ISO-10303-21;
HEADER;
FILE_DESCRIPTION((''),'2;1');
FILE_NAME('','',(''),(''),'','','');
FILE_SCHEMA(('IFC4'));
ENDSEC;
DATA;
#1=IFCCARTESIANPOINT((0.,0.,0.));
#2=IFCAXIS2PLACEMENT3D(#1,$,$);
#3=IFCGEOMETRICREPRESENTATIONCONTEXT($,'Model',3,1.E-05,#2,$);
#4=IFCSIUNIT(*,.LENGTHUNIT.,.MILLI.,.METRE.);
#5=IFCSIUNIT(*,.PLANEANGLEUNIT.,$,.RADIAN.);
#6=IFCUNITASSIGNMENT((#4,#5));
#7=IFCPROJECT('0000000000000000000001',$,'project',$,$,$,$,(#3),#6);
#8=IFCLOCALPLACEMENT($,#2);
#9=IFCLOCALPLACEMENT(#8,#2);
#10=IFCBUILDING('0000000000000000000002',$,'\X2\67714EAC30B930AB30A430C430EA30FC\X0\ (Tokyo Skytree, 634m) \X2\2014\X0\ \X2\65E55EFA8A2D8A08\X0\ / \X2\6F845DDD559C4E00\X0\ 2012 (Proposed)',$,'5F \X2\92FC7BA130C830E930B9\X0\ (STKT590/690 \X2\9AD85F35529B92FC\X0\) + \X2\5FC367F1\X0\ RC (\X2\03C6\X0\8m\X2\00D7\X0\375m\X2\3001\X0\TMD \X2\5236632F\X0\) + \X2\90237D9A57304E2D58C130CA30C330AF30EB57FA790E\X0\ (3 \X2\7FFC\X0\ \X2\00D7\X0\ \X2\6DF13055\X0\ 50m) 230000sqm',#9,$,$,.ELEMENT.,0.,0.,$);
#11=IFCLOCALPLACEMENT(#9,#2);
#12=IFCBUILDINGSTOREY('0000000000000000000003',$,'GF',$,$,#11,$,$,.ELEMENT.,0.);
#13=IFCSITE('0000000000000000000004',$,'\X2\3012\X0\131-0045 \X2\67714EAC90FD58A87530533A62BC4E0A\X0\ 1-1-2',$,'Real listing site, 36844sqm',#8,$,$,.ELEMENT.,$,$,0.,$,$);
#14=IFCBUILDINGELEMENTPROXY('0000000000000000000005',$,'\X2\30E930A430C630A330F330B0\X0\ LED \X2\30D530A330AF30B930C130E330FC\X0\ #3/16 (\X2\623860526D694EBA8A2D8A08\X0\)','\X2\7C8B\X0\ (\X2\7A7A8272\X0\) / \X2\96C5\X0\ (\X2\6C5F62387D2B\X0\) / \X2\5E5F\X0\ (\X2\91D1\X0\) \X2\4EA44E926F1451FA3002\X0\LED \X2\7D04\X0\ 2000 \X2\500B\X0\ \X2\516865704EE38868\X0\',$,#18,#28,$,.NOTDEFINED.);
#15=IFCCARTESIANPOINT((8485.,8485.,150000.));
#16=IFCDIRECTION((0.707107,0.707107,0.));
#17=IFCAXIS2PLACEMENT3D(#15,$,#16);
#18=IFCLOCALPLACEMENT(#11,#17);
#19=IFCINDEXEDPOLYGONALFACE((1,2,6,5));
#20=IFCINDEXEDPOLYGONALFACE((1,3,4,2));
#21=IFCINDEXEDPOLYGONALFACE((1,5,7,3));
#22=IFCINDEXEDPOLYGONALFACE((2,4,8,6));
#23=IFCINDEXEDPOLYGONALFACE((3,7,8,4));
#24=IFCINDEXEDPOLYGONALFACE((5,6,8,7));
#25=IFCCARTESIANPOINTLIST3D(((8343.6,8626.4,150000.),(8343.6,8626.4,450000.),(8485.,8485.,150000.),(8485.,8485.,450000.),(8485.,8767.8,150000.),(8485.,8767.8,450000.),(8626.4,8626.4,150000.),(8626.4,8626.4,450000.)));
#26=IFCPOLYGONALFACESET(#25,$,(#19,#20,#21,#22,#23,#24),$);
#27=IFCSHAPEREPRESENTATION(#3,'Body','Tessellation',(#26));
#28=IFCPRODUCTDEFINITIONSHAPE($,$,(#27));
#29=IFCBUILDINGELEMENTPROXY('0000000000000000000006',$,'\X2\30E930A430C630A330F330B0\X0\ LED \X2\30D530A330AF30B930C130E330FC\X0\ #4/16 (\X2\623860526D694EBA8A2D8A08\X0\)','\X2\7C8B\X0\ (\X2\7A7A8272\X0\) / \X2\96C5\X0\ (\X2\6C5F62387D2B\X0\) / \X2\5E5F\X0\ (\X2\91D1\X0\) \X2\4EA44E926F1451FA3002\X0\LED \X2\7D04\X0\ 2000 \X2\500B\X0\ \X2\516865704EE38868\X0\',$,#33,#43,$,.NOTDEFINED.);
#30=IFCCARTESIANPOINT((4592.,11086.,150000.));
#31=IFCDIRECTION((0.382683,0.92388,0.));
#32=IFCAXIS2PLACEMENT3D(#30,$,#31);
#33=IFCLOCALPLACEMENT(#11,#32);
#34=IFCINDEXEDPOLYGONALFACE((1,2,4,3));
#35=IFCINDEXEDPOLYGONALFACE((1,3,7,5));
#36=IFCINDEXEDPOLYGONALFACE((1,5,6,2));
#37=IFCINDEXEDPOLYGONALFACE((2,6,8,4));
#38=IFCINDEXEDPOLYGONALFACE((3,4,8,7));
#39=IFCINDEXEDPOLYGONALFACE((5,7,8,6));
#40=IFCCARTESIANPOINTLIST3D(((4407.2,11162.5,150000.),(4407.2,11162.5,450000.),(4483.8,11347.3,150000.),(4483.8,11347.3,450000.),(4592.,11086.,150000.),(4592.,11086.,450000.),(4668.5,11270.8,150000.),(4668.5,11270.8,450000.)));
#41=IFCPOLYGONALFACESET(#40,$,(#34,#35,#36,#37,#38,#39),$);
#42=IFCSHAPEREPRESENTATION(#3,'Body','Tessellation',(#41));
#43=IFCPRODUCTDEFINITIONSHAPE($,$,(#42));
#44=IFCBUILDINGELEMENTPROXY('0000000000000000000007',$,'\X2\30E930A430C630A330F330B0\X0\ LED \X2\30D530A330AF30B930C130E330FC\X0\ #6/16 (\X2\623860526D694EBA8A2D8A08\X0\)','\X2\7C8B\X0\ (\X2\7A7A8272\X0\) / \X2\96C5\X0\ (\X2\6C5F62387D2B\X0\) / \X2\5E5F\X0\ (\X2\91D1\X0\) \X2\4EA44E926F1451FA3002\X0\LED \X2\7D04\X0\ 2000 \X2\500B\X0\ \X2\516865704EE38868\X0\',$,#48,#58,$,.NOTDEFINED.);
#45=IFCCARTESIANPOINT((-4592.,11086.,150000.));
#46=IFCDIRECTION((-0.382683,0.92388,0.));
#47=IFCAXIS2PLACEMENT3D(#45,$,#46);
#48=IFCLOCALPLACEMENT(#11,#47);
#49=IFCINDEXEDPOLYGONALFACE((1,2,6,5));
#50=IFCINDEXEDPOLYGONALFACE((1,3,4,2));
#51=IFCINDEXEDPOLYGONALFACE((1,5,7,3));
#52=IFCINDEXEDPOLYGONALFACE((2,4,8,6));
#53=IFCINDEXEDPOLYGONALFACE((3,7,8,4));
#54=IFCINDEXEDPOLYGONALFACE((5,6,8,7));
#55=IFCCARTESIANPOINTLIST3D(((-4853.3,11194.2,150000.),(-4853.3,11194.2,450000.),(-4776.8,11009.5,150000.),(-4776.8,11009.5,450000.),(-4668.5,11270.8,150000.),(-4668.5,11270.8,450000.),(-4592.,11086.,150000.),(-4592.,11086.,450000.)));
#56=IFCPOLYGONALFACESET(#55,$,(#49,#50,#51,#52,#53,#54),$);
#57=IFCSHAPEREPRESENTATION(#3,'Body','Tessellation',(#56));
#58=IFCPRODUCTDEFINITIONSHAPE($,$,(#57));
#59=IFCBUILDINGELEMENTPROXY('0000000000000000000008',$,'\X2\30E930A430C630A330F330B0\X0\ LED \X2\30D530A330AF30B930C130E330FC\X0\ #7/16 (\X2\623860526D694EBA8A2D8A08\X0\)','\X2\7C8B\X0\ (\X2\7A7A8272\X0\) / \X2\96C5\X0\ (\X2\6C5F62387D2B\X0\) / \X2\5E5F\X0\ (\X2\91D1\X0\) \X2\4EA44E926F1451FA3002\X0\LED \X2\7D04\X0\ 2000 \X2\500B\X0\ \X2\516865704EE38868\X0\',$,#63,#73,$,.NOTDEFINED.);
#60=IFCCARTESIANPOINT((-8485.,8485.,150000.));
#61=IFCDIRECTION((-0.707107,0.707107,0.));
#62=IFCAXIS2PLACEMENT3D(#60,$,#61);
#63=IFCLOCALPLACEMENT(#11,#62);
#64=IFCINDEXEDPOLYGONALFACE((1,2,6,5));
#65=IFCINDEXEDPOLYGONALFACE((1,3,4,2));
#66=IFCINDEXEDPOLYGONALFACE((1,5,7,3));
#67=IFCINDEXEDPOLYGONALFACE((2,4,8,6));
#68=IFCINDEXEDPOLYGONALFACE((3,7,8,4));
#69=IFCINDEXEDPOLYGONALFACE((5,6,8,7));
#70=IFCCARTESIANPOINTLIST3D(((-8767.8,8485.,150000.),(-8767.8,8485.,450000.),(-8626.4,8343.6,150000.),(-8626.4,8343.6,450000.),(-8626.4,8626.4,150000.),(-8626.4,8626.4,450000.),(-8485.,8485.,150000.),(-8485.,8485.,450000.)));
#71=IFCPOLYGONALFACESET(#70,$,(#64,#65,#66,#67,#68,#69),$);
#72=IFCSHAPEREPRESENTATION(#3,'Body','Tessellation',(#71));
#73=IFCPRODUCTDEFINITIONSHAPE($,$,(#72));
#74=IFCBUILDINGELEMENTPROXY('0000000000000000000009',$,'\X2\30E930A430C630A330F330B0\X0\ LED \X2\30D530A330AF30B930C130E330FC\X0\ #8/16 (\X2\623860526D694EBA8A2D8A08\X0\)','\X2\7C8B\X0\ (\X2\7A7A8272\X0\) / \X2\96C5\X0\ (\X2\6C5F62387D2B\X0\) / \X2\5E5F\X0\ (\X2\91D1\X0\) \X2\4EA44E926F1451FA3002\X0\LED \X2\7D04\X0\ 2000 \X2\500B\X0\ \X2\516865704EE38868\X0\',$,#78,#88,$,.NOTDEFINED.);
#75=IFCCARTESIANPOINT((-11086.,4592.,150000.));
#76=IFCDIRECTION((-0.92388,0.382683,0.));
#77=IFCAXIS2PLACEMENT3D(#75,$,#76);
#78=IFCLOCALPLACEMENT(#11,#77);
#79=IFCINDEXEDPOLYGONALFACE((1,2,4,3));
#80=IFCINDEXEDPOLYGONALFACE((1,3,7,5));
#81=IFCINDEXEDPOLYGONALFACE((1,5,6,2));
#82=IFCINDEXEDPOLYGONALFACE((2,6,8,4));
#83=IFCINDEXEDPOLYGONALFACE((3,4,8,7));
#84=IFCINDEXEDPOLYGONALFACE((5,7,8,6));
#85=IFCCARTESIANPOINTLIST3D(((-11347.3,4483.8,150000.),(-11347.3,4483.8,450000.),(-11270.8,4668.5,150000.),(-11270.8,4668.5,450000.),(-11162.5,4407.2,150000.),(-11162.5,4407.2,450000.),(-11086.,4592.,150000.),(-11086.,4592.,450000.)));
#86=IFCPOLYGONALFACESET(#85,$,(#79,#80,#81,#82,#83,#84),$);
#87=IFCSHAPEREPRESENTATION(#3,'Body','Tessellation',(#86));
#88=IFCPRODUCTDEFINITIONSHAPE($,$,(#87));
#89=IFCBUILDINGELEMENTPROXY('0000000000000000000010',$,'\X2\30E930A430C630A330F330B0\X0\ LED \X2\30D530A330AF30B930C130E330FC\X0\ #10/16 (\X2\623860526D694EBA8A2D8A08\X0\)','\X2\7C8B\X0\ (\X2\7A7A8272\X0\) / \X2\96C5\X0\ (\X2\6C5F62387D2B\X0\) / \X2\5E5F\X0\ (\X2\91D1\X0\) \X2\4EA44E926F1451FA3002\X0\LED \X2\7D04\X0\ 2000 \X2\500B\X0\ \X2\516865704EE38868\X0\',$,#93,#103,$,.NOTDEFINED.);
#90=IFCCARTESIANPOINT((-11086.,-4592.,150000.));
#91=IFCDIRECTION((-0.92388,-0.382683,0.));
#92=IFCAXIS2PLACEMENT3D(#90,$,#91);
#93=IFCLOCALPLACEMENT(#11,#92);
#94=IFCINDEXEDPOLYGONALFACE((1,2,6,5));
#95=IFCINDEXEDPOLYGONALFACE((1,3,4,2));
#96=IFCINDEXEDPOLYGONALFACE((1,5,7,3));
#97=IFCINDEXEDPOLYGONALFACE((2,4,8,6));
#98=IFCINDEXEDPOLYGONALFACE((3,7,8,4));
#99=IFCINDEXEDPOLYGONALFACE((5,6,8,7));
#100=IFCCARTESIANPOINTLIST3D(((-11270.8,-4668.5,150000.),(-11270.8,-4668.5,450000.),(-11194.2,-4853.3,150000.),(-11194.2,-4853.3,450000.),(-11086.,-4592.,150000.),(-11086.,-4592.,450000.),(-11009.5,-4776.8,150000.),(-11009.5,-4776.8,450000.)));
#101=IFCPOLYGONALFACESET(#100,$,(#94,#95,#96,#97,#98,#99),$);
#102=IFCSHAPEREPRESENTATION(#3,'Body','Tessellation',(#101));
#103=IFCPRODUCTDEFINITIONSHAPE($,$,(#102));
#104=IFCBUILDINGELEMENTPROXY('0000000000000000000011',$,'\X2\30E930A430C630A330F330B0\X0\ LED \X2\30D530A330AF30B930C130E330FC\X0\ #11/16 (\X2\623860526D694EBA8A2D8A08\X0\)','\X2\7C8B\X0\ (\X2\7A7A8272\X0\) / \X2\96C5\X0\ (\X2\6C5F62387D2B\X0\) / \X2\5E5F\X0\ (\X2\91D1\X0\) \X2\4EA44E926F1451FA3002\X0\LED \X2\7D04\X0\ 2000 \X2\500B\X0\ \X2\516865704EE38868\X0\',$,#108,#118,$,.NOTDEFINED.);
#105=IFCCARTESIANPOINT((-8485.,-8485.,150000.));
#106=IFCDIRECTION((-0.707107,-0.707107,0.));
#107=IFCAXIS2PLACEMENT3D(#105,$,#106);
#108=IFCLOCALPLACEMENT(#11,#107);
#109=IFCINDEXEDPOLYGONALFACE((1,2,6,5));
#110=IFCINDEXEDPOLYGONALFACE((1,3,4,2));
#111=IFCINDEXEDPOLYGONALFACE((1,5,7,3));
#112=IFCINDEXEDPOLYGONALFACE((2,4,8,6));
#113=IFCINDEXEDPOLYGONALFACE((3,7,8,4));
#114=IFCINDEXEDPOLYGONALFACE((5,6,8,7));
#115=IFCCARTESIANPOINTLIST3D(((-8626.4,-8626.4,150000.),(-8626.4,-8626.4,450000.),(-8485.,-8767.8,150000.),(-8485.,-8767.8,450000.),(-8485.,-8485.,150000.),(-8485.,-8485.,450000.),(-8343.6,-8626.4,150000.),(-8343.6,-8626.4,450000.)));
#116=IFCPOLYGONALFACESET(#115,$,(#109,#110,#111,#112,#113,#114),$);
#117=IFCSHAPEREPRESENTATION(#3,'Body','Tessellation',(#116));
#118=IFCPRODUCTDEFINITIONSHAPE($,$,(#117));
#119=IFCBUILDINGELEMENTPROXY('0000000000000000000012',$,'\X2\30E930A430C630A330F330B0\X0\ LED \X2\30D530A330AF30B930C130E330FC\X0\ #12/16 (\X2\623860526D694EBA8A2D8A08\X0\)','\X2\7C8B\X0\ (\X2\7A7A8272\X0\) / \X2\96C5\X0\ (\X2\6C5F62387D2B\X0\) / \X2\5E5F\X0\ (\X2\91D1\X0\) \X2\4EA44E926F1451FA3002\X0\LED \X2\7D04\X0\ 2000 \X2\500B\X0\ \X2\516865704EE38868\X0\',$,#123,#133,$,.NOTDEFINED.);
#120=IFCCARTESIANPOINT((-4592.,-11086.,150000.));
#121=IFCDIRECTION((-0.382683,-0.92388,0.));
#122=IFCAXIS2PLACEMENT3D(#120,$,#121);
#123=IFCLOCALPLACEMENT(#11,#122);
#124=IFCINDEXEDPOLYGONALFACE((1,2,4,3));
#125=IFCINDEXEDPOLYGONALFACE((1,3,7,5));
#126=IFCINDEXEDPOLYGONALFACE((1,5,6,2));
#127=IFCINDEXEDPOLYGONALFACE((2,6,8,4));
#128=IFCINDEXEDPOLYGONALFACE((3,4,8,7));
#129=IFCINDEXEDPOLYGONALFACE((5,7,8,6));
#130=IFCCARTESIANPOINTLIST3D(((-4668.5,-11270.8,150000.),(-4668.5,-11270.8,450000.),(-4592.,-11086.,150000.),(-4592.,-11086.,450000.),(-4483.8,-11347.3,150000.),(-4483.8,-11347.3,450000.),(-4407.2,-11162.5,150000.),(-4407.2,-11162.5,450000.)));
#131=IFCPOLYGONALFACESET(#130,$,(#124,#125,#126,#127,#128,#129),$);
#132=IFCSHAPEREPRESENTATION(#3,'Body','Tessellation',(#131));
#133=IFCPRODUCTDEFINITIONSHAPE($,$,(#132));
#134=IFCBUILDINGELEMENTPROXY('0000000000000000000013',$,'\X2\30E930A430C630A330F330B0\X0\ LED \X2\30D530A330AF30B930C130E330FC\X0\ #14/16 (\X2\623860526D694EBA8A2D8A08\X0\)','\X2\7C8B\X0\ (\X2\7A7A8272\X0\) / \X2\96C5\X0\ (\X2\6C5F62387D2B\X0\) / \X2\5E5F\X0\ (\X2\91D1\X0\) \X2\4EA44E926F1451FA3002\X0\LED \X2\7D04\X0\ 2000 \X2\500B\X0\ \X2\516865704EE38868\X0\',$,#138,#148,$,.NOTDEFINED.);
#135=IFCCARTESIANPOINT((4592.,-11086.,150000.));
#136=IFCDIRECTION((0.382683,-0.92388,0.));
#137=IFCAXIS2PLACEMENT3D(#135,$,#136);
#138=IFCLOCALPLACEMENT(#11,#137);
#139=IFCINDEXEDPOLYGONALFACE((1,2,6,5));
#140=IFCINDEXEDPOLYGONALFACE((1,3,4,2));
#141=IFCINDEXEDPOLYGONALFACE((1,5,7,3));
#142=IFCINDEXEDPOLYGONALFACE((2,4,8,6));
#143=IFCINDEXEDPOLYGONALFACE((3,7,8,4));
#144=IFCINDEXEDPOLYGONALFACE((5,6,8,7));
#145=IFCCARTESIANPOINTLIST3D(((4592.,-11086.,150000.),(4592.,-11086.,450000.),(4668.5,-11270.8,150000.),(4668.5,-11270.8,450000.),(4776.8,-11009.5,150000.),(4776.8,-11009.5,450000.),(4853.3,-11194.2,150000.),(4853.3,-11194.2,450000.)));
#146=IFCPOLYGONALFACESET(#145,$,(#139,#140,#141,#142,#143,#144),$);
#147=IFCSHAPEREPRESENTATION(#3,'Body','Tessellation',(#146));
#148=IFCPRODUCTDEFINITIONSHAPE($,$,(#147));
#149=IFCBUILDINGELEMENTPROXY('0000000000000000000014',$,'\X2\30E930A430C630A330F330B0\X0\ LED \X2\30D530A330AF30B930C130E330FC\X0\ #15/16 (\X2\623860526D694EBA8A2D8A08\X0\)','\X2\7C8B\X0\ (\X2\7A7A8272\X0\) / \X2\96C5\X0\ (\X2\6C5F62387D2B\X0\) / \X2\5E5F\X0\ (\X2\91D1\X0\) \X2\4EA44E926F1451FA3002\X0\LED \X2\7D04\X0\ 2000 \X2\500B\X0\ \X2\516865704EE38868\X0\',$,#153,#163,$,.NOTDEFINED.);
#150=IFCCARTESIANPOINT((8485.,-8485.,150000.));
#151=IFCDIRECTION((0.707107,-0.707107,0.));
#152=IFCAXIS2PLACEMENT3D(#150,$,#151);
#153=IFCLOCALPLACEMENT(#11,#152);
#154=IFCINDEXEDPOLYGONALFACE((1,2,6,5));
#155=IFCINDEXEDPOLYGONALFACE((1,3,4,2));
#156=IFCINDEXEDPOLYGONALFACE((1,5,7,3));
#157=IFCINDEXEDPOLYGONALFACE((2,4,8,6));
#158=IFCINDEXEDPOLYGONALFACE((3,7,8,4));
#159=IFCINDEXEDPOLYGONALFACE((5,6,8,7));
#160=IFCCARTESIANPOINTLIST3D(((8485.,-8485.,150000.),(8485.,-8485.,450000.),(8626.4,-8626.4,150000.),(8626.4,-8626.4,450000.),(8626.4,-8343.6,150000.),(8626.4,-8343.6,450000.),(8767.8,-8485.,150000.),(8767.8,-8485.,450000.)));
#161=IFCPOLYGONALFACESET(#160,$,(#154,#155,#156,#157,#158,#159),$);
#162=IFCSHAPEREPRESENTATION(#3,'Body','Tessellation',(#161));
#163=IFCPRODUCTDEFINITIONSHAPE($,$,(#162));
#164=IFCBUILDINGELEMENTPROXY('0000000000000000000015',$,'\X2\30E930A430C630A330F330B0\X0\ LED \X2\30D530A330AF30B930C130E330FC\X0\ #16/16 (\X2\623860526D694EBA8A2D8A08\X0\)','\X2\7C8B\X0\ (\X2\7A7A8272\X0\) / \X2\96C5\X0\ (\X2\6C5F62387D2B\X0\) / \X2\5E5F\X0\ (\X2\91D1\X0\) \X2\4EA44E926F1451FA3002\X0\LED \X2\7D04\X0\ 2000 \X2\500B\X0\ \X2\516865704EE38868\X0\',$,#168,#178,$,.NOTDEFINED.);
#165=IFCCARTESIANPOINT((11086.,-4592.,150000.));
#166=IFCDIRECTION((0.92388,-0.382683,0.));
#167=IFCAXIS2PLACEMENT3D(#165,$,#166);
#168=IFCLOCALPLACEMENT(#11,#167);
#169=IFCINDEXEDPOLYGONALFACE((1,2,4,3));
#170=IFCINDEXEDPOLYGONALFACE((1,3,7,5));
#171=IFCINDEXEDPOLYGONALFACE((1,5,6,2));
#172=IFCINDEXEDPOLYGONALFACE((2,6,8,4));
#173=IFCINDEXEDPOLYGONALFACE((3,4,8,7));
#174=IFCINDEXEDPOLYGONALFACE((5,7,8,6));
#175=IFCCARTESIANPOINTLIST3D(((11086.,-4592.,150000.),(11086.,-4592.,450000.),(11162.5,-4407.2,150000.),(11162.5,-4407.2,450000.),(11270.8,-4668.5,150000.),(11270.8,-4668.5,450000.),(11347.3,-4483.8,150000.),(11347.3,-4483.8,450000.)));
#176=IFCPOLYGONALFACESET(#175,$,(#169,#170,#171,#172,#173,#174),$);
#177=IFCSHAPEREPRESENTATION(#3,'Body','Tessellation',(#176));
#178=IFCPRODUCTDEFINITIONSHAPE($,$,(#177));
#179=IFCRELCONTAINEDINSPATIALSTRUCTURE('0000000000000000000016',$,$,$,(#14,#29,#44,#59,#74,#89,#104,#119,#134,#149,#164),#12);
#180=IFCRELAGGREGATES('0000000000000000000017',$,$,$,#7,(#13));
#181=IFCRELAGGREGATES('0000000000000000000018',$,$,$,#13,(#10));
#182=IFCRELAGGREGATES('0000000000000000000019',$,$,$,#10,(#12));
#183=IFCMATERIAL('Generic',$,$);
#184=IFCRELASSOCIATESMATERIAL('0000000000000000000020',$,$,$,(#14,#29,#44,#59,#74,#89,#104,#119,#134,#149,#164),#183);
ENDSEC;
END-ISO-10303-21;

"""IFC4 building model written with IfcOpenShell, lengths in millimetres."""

from ifc_helpers import new_model, si_unit, frame, frame_2d, origin, place, context, project, spatial, rectangle, extrude, material, element, save


model = new_model("IFC4")

# Units and contexts
model_context = context("Model", 3, precision=1e-05, world=origin())
ifc_project = project(units=[si_unit("LENGTHUNIT", "METRE", prefix="MILLI"), si_unit("PLANEANGLEUNIT", "RADIAN")], contexts=[model_context])

# Site, building, storey
site_placement = place(None, origin())
site = spatial("IfcSite", under=ifc_project, at=site_placement, Name="〒131-0045 東京都墨田区押上 1-1-2", ObjectType="Real listing site, 36844sqm", CompositionType="ELEMENT", RefElevation=0.0)
building_placement = place(site_placement, origin())
building = spatial("IfcBuilding", under=site, at=building_placement, Name="東京スカイツリー (Tokyo Skytree, 634m) — 日建設計 / 澄川喜一 2012 (Proposed)", ObjectType="5F 鋼管トラス (STKT590/690 高張力鋼) + 心柱 RC (φ8m×375m、TMD 制振) + 連続地中壁ナックル基礎 (3 翼 × 深さ 50m) 230000sqm", CompositionType="ELEMENT", ElevationOfRefHeight=0.0, ElevationOfTerrain=0.0)
storey_placement = place(building_placement, origin())
storey = spatial("IfcBuildingStorey", under=building, at=storey_placement, Name="GF", CompositionType="ELEMENT", Elevation=0.0)

# Shared definitions
ifc_material = material(Name="Generic")

# Building element proxies
proxy_1_placement = place(storey_placement, frame((8485.0, 8485.0, 150000.0), x_axis=(0.707107, 0.707107, 0.0)))
element("IfcBuildingElementProxy", 1, at=proxy_1_placement, inside=storey, material=ifc_material, Name="ライティング LED フィクスチャー #3/16 (戸恒浩人設計)", Description="粋 (空色) / 雅 (江戸紫) / 幟 (金) 交互演出。LED 約 2000 個 全数代表", PredefinedType="NOTDEFINED", context=model_context, shape_type="SweptSolid", body=[
    extrude(rectangle(XDim=200.0, YDim=200.0, at=frame_2d((100.0, 100.0))), frame((8485.0, 8485.0, 150000.0), x_axis=(0.707107, 0.707107, 0.0)), (0.0, 0.0, 1.0), 300000.0),
])
proxy_2_placement = place(storey_placement, frame((4592.0, 11086.0, 150000.0), x_axis=(0.382683, 0.92388, 0.0)))
element("IfcBuildingElementProxy", 2, at=proxy_2_placement, inside=storey, material=ifc_material, Name="ライティング LED フィクスチャー #4/16 (戸恒浩人設計)", Description="粋 (空色) / 雅 (江戸紫) / 幟 (金) 交互演出。LED 約 2000 個 全数代表", PredefinedType="NOTDEFINED", context=model_context, shape_type="SweptSolid", body=[
    extrude(rectangle(XDim=200.0, YDim=200.0, at=frame_2d((100.0, 100.0))), frame((4592.0, 11086.0, 150000.0), x_axis=(0.382683, 0.92388, 0.0)), (0.0, 0.0, 1.0), 300000.0),
])
proxy_3_placement = place(storey_placement, frame((-4592.0, 11086.0, 150000.0), x_axis=(-0.382683, 0.92388, 0.0)))
element("IfcBuildingElementProxy", 3, at=proxy_3_placement, inside=storey, material=ifc_material, Name="ライティング LED フィクスチャー #6/16 (戸恒浩人設計)", Description="粋 (空色) / 雅 (江戸紫) / 幟 (金) 交互演出。LED 約 2000 個 全数代表", PredefinedType="NOTDEFINED", context=model_context, shape_type="SweptSolid", body=[
    extrude(rectangle(XDim=200.0, YDim=200.0, at=frame_2d((100.0, 100.0))), frame((-4592.0, 11086.0, 150000.0), x_axis=(-0.382683, 0.92388, 0.0)), (0.0, 0.0, 1.0), 300000.0),
])
proxy_4_placement = place(storey_placement, frame((-8485.0, 8485.0, 150000.0), x_axis=(-0.707107, 0.707107, 0.0)))
element("IfcBuildingElementProxy", 4, at=proxy_4_placement, inside=storey, material=ifc_material, Name="ライティング LED フィクスチャー #7/16 (戸恒浩人設計)", Description="粋 (空色) / 雅 (江戸紫) / 幟 (金) 交互演出。LED 約 2000 個 全数代表", PredefinedType="NOTDEFINED", context=model_context, shape_type="SweptSolid", body=[
    extrude(rectangle(XDim=200.0, YDim=200.0, at=frame_2d((100.0, 100.0))), frame((-8485.0, 8485.0, 150000.0), x_axis=(-0.707107, 0.707107, 0.0)), (0.0, 0.0, 1.0), 300000.0),
])
proxy_5_placement = place(storey_placement, frame((-11086.0, 4592.0, 150000.0), x_axis=(-0.92388, 0.382683, 0.0)))
element("IfcBuildingElementProxy", 5, at=proxy_5_placement, inside=storey, material=ifc_material, Name="ライティング LED フィクスチャー #8/16 (戸恒浩人設計)", Description="粋 (空色) / 雅 (江戸紫) / 幟 (金) 交互演出。LED 約 2000 個 全数代表", PredefinedType="NOTDEFINED", context=model_context, shape_type="SweptSolid", body=[
    extrude(rectangle(XDim=200.0, YDim=200.0, at=frame_2d((100.0, 100.0))), frame((-11086.0, 4592.0, 150000.0), x_axis=(-0.92388, 0.382683, 0.0)), (0.0, 0.0, 1.0), 300000.0),
])
proxy_6_placement = place(storey_placement, frame((-11086.0, -4592.0, 150000.0), x_axis=(-0.92388, -0.382683, 0.0)))
element("IfcBuildingElementProxy", 6, at=proxy_6_placement, inside=storey, material=ifc_material, Name="ライティング LED フィクスチャー #10/16 (戸恒浩人設計)", Description="粋 (空色) / 雅 (江戸紫) / 幟 (金) 交互演出。LED 約 2000 個 全数代表", PredefinedType="NOTDEFINED", context=model_context, shape_type="SweptSolid", body=[
    extrude(rectangle(XDim=200.0, YDim=200.0, at=frame_2d((100.0, 100.0))), frame((-11086.0, -4592.0, 150000.0), x_axis=(-0.92388, -0.382683, 0.0)), (0.0, 0.0, 1.0), 300000.0),
])
proxy_7_placement = place(storey_placement, frame((-8485.0, -8485.0, 150000.0), x_axis=(-0.707107, -0.707107, 0.0)))
element("IfcBuildingElementProxy", 7, at=proxy_7_placement, inside=storey, material=ifc_material, Name="ライティング LED フィクスチャー #11/16 (戸恒浩人設計)", Description="粋 (空色) / 雅 (江戸紫) / 幟 (金) 交互演出。LED 約 2000 個 全数代表", PredefinedType="NOTDEFINED", context=model_context, shape_type="SweptSolid", body=[
    extrude(rectangle(XDim=200.0, YDim=200.0, at=frame_2d((100.0, 100.0))), frame((-8485.0, -8485.0, 150000.0), x_axis=(-0.707107, -0.707107, 0.0)), (0.0, 0.0, 1.0), 300000.0),
])
proxy_8_placement = place(storey_placement, frame((-4592.0, -11086.0, 150000.0), x_axis=(-0.382683, -0.92388, 0.0)))
element("IfcBuildingElementProxy", 8, at=proxy_8_placement, inside=storey, material=ifc_material, Name="ライティング LED フィクスチャー #12/16 (戸恒浩人設計)", Description="粋 (空色) / 雅 (江戸紫) / 幟 (金) 交互演出。LED 約 2000 個 全数代表", PredefinedType="NOTDEFINED", context=model_context, shape_type="SweptSolid", body=[
    extrude(rectangle(XDim=200.0, YDim=200.0, at=frame_2d((100.0, 100.0))), frame((-4592.0, -11086.0, 150000.0), x_axis=(-0.382683, -0.92388, 0.0)), (0.0, 0.0, 1.0), 300000.0),
])
proxy_9_placement = place(storey_placement, frame((4592.0, -11086.0, 150000.0), x_axis=(0.382683, -0.92388, 0.0)))
element("IfcBuildingElementProxy", 9, at=proxy_9_placement, inside=storey, material=ifc_material, Name="ライティング LED フィクスチャー #14/16 (戸恒浩人設計)", Description="粋 (空色) / 雅 (江戸紫) / 幟 (金) 交互演出。LED 約 2000 個 全数代表", PredefinedType="NOTDEFINED", context=model_context, shape_type="SweptSolid", body=[
    extrude(rectangle(XDim=200.0, YDim=200.0, at=frame_2d((100.0, 100.0))), frame((4592.0, -11086.0, 150000.0), x_axis=(0.382683, -0.92388, 0.0)), (0.0, 0.0, 1.0), 300000.0),
])
proxy_10_placement = place(storey_placement, frame((8485.0, -8485.0, 150000.0), x_axis=(0.707107, -0.707107, 0.0)))
element("IfcBuildingElementProxy", 10, at=proxy_10_placement, inside=storey, material=ifc_material, Name="ライティング LED フィクスチャー #15/16 (戸恒浩人設計)", Description="粋 (空色) / 雅 (江戸紫) / 幟 (金) 交互演出。LED 約 2000 個 全数代表", PredefinedType="NOTDEFINED", context=model_context, shape_type="SweptSolid", body=[
    extrude(rectangle(XDim=200.0, YDim=200.0, at=frame_2d((100.0, 100.0))), frame((8485.0, -8485.0, 150000.0), x_axis=(0.707107, -0.707107, 0.0)), (0.0, 0.0, 1.0), 300000.0),
])
proxy_11_placement = place(storey_placement, frame((11086.0, -4592.0, 150000.0), x_axis=(0.92388, -0.382683, 0.0)))
element("IfcBuildingElementProxy", 11, at=proxy_11_placement, inside=storey, material=ifc_material, Name="ライティング LED フィクスチャー #16/16 (戸恒浩人設計)", Description="粋 (空色) / 雅 (江戸紫) / 幟 (金) 交互演出。LED 約 2000 個 全数代表", PredefinedType="NOTDEFINED", context=model_context, shape_type="SweptSolid", body=[
    extrude(rectangle(XDim=200.0, YDim=200.0, at=frame_2d((100.0, 100.0))), frame((11086.0, -4592.0, 150000.0), x_axis=(0.92388, -0.382683, 0.0)), (0.0, 0.0, 1.0), 300000.0),
])

save(model, "model.ifc")
